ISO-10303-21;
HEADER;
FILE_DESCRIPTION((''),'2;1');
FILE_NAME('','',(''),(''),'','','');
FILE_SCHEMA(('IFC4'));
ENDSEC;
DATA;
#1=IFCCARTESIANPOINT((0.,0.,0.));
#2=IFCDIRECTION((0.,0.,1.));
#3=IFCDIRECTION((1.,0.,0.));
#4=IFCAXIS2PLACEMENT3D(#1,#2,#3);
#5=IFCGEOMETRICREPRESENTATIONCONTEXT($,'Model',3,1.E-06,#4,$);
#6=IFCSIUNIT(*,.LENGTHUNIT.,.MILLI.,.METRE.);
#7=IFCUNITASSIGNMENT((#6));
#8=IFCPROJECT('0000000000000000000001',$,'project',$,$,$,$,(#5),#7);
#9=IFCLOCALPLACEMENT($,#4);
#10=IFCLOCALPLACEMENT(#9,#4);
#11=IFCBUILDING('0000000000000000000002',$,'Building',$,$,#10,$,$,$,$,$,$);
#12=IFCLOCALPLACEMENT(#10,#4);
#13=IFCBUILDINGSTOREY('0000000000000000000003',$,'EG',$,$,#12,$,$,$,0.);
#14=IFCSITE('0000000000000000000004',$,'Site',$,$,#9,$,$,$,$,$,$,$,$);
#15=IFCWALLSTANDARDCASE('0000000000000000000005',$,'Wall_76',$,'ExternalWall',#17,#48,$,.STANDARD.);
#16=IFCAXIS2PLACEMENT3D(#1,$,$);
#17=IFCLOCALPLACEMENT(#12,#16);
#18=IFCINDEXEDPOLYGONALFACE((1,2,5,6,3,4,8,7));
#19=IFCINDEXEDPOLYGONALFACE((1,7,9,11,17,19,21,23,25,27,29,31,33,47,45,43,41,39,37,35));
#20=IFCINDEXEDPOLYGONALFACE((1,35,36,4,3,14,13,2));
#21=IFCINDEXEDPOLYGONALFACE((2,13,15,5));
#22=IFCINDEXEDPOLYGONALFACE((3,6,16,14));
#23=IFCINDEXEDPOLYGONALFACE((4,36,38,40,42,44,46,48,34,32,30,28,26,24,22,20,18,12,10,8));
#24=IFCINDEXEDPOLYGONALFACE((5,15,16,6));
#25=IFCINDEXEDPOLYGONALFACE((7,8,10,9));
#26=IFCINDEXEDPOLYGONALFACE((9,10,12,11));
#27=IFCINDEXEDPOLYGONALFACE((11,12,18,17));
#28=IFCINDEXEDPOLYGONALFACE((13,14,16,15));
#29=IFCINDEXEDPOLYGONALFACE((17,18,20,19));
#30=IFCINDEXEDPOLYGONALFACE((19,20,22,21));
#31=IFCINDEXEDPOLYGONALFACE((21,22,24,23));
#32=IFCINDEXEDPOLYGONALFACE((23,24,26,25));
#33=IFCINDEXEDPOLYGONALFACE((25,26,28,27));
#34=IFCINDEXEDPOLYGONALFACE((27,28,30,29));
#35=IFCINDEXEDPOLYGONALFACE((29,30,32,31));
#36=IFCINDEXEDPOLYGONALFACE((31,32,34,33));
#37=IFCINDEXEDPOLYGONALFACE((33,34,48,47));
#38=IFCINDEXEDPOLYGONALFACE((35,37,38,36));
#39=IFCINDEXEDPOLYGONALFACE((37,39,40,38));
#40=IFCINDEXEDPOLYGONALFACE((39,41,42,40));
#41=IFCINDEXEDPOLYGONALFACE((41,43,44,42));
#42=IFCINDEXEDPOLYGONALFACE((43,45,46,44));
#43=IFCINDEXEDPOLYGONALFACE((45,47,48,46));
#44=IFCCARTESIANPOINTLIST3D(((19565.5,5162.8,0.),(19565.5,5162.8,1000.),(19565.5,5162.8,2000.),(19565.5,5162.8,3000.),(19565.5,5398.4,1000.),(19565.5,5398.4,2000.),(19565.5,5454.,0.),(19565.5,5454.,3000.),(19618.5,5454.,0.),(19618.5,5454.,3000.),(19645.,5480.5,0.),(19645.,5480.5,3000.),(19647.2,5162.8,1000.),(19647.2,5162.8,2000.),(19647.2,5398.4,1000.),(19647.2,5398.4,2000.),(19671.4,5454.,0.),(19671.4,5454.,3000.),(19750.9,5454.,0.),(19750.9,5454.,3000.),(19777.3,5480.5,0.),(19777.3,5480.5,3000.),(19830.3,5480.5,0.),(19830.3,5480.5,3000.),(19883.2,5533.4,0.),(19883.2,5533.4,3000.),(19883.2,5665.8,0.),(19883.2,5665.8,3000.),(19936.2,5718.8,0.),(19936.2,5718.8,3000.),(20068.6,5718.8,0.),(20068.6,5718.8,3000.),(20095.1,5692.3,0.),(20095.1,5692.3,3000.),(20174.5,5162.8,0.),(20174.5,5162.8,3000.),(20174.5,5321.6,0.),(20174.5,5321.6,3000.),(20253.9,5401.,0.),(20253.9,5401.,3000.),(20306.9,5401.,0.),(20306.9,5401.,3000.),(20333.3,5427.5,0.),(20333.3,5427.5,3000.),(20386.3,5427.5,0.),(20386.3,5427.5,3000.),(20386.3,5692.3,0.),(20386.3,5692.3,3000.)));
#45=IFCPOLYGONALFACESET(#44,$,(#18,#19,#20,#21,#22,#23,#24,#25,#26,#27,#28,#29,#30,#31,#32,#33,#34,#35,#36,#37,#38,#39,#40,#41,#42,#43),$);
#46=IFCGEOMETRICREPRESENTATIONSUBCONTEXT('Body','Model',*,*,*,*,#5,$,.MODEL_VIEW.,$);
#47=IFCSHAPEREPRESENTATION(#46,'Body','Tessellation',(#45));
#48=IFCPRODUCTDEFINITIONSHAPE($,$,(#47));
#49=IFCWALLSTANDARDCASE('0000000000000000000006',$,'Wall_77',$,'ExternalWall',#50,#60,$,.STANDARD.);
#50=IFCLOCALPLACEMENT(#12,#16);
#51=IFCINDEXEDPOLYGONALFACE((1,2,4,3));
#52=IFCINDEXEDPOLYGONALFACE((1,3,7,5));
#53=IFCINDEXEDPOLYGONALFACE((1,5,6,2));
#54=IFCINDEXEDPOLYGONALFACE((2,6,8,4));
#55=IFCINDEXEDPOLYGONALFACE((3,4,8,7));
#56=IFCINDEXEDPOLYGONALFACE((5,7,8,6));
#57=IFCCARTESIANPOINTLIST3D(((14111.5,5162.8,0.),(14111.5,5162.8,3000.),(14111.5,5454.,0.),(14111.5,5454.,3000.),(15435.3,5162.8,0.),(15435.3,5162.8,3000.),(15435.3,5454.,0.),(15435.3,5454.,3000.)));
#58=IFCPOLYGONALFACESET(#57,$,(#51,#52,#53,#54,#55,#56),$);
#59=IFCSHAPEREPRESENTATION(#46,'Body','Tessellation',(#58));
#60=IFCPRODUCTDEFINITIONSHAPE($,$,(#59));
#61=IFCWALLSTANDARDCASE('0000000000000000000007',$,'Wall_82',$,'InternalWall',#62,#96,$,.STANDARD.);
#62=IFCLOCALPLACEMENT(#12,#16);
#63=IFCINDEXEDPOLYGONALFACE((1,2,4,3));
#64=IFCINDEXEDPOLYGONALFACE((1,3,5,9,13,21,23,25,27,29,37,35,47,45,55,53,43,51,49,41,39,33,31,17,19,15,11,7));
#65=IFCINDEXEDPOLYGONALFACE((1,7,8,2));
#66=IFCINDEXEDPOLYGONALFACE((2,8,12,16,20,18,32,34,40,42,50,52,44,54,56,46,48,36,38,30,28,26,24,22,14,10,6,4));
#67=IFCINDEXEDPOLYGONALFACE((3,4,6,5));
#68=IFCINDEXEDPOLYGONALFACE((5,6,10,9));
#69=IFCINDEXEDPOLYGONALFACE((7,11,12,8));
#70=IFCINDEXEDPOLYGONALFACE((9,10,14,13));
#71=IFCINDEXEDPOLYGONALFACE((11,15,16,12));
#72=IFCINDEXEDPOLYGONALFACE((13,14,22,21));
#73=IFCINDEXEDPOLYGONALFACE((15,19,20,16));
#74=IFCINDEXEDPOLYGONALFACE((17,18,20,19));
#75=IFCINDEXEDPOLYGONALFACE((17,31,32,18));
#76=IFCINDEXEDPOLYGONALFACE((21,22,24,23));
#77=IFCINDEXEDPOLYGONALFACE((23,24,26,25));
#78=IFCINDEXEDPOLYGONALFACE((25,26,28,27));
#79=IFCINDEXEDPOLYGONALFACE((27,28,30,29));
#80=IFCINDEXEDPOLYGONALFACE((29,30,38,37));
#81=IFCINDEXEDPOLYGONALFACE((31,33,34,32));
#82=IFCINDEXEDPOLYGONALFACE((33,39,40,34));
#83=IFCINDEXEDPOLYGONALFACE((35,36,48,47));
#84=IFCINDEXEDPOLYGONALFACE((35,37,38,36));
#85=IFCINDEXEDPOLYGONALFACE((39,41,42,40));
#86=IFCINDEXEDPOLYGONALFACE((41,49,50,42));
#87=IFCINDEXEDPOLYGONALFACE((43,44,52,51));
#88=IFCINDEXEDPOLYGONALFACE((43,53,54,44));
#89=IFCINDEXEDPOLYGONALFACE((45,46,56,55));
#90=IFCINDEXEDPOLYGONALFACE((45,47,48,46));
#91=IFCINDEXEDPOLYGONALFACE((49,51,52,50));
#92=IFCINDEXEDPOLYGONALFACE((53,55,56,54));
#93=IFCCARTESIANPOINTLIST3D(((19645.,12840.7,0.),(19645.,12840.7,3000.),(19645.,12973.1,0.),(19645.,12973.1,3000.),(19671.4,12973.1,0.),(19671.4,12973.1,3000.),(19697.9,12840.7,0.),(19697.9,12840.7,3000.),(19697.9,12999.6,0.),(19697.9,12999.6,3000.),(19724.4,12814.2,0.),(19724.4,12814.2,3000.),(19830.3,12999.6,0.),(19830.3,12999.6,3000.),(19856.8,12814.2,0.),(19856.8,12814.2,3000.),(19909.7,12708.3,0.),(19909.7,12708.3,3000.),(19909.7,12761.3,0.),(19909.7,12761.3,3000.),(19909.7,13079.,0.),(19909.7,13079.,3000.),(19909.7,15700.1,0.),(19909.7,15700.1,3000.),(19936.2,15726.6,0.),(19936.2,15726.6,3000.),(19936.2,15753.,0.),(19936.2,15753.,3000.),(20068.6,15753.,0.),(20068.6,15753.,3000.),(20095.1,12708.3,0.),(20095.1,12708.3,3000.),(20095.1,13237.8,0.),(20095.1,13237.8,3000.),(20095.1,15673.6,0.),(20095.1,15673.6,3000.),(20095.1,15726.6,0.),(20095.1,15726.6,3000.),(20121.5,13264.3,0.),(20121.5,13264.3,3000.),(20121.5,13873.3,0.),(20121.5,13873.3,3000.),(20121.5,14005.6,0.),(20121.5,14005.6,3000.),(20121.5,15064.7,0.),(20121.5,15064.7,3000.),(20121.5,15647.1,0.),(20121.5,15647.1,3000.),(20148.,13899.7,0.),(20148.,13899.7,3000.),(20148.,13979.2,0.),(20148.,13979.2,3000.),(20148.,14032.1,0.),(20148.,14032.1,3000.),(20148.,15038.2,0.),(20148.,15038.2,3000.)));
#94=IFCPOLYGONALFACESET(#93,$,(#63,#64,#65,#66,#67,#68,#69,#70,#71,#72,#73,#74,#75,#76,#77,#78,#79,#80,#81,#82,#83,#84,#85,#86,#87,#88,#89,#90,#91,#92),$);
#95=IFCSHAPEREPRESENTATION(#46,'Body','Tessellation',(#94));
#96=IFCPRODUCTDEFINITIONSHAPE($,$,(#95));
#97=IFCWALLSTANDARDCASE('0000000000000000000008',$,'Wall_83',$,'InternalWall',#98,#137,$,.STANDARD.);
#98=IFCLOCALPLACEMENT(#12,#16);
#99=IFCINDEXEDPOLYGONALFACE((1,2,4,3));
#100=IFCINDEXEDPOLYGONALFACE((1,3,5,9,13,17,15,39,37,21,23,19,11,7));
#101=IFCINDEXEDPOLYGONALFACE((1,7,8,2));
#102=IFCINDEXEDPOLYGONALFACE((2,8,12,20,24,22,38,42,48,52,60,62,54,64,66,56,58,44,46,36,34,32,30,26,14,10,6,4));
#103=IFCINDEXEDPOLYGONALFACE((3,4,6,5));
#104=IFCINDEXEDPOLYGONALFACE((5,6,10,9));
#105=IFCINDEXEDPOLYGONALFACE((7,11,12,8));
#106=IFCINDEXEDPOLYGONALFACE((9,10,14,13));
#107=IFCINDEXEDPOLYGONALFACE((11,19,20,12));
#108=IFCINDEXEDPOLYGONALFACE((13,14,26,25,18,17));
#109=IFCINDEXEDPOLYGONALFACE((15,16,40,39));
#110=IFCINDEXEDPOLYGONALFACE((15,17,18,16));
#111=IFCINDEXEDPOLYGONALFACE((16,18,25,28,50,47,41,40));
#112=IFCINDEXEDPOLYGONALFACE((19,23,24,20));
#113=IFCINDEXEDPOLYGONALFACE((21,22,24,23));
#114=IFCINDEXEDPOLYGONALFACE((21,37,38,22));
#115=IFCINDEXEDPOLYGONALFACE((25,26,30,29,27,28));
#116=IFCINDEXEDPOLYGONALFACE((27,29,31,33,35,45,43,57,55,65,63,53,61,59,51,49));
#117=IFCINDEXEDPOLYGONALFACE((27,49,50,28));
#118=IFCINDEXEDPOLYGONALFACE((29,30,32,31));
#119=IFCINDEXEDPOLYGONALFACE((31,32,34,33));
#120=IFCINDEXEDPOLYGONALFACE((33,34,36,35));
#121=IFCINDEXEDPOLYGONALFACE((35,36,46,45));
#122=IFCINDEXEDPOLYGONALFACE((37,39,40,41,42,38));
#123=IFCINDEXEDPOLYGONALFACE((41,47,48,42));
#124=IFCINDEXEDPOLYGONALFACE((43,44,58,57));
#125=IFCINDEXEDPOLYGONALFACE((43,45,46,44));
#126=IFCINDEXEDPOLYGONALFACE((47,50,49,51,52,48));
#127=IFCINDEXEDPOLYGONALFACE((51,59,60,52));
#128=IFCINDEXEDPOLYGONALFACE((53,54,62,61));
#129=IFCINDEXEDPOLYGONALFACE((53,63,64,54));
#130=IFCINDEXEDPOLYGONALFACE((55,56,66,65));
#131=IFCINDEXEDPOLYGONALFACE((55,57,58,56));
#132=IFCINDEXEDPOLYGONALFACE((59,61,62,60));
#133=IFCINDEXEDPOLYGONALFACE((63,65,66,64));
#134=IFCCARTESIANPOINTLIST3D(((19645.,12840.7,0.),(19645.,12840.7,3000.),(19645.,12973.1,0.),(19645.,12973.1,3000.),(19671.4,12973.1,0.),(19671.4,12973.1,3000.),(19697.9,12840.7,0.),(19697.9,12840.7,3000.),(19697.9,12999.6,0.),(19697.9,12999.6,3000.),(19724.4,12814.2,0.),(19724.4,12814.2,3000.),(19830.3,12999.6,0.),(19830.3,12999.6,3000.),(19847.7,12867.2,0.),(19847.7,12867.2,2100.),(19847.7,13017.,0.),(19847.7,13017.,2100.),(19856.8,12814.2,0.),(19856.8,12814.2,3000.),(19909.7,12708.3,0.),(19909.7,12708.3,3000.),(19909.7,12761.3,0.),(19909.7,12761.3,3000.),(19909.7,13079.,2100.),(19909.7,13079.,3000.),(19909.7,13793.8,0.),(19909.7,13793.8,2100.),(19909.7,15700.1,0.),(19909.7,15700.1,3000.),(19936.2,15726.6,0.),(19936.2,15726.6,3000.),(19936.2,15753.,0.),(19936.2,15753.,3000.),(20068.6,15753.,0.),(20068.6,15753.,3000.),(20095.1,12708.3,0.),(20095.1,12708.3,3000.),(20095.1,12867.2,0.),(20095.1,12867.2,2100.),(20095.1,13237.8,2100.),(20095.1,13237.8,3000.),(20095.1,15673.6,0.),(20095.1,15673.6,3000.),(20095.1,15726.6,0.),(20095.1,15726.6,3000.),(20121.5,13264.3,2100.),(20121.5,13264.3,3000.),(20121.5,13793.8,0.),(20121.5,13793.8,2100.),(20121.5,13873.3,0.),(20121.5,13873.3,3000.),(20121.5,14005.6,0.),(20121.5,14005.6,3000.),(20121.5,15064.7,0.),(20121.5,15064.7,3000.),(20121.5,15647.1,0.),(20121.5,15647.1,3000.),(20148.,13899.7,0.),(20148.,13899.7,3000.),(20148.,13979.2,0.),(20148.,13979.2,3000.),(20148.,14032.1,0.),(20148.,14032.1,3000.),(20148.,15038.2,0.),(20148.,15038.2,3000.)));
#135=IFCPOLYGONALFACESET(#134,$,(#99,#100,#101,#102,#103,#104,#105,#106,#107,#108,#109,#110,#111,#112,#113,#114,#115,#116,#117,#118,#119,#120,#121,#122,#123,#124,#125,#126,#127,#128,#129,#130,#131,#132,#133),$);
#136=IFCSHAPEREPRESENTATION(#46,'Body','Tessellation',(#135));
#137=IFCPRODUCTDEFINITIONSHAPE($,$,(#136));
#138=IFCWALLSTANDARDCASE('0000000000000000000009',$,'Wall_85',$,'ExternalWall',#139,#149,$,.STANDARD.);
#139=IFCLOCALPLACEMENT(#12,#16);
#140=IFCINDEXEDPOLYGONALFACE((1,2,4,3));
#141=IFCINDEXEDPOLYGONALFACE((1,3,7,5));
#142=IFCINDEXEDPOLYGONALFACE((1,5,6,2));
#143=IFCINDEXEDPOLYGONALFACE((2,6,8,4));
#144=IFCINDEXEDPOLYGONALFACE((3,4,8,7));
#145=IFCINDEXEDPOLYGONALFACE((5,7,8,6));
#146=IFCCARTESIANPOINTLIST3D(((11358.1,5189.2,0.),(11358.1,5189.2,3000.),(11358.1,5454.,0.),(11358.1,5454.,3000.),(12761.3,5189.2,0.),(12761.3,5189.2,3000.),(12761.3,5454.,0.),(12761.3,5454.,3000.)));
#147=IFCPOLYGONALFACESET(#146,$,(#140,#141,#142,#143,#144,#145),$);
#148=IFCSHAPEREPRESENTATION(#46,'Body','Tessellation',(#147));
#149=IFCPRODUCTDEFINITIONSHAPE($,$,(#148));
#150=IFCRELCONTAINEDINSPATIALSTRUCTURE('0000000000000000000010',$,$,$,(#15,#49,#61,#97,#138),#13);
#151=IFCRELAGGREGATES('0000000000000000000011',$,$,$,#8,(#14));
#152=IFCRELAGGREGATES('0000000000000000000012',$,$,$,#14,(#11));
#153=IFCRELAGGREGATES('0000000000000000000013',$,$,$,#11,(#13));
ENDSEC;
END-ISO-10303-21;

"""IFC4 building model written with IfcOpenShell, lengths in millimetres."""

from ifc_helpers import new_model, si_unit, frame, origin_with_axes, place, context, subcontext, project, spatial, polyline, rectangle, outline, extrude, element, save


model = new_model("IFC4")

# Units and contexts
model_context = context("Model", 3, precision=1e-06, world=origin_with_axes())
body_context = subcontext(model_context, "Body", "Model", "MODEL_VIEW")
ifc_project = project(units=[si_unit("LENGTHUNIT", "METRE", prefix="MILLI")], contexts=[model_context])

# Site, building, storey
site_placement = place(None, origin_with_axes())
site = spatial("IfcSite", under=ifc_project, at=site_placement, Name="Site")
building_placement = place(site_placement, origin_with_axes())
building = spatial("IfcBuilding", under=site, at=building_placement, Name="Building")
storey_placement = place(building_placement, origin_with_axes())
storey = spatial("IfcBuildingStorey", under=building, at=storey_placement, Name="EG", Elevation=0.0)

# Wall, opening
wall_1_placement = place(storey_placement, origin_with_axes())
wall_1 = element("IfcWallStandardCase", 1, at=wall_1_placement, inside=storey, Name="Wall_76", ObjectType="ExternalWall", PredefinedType="STANDARD", context=body_context, shape_type="SweptSolid", body=[
    extrude(outline(polyline([(19565.5, 5162.8, 0.0), (19565.5, 5454.0, 0.0), (19618.5, 5454.0, 0.0), (19645.0, 5480.5, 0.0), (19671.4, 5454.0, 0.0), (19750.9, 5454.0, 0.0), (19777.3, 5480.5, 0.0), (19830.3, 5480.5, 0.0), (19883.2, 5533.4, 0.0), (19883.2, 5665.8, 0.0), (19936.2, 5718.8, 0.0), (20068.6, 5718.8, 0.0), (20095.1, 5692.3, 0.0), (20386.3, 5692.3, 0.0), (20386.3, 5427.5, 0.0), (20333.3, 5427.5, 0.0), (20306.9, 5401.0, 0.0), (20253.9, 5401.0, 0.0), (20174.5, 5321.6, 0.0), (20174.5, 5162.8, 0.0), (19565.5, 5162.8, 0.0)])), origin_with_axes(), (0.0, 0.0, 1.0), 3000.0),
])
opening_1_placement = place(wall_1_placement, origin_with_axes())
element("IfcOpeningElement", 2, at=opening_1_placement, inside=storey, cuts=wall_1, context=body_context, shape_type="SweptSolid", body=[
    extrude(rectangle(XDim=694.1, YDim=240.0), frame((19527.2, 5051.4, 1000.0), z_axis=(0.0, 0.0, 1.0), x_axis=(0.0, 1.0, 0.0)), (0.0, 0.0, 1.0), 1000.0),
])

# Walls
for number, where, z_axis, x_axis, name in (
    (3, (0.0, 0.0, 0.0), (0.0, 0.0, 1.0), (1.0, 0.0, 0.0), "Wall_77"),
):
    element("IfcWallStandardCase", number, at=place(storey_placement, frame(where, z_axis=z_axis, x_axis=x_axis)), inside=storey, Name=name, ObjectType="ExternalWall", PredefinedType="STANDARD", context=body_context, shape_type="SweptSolid", body=[
        extrude(outline(polyline([(14111.5, 5162.8, 0.0), (14111.5, 5454.0, 0.0), (15435.3, 5454.0, 0.0), (15435.3, 5162.8, 0.0), (14111.5, 5162.8, 0.0)])), origin_with_axes(), (0.0, 0.0, 1.0), 3000.0),
    ])
wall_2_placement = place(storey_placement, origin_with_axes())
element("IfcWallStandardCase", 4, at=wall_2_placement, inside=storey, Name="Wall_82", ObjectType="InternalWall", PredefinedType="STANDARD", context=body_context, shape_type="SweptSolid", body=[
    extrude(outline(polyline([(19909.7, 12708.3, 0.0), (19909.7, 12761.3, 0.0), (19856.8, 12814.2, 0.0), (19724.4, 12814.2, 0.0), (19697.9, 12840.7, 0.0), (19645.0, 12840.7, 0.0), (19645.0, 12973.1, 0.0), (19671.4, 12973.1, 0.0), (19697.9, 12999.6, 0.0), (19830.3, 12999.6, 0.0), (19909.7, 13079.0, 0.0), (19909.7, 15700.1, 0.0), (19936.2, 15726.6, 0.0), (19936.2, 15753.0, 0.0), (20068.6, 15753.0, 0.0), (20095.1, 15726.6, 0.0), (20095.1, 15673.6, 0.0), (20121.5, 15647.1, 0.0), (20121.5, 15064.7, 0.0), (20148.0, 15038.2, 0.0), (20148.0, 14032.1, 0.0), (20121.5, 14005.6, 0.0), (20148.0, 13979.2, 0.0), (20148.0, 13899.7, 0.0), (20121.5, 13873.3, 0.0), (20121.5, 13264.3, 0.0), (20095.1, 13237.8, 0.0), (20095.1, 12708.3, 0.0), (19909.7, 12708.3, 0.0)])), origin_with_axes(), (0.0, 0.0, 1.0), 3000.0),
])

# Wall, opening
wall_3_placement = place(storey_placement, origin_with_axes())
wall_3 = element("IfcWallStandardCase", 5, at=wall_3_placement, inside=storey, Name="Wall_83", ObjectType="InternalWall", PredefinedType="STANDARD", context=body_context, shape_type="SweptSolid", body=[
    extrude(outline(polyline([(19909.7, 12708.3, 0.0), (19909.7, 12761.3, 0.0), (19856.8, 12814.2, 0.0), (19724.4, 12814.2, 0.0), (19697.9, 12840.7, 0.0), (19645.0, 12840.7, 0.0), (19645.0, 12973.1, 0.0), (19671.4, 12973.1, 0.0), (19697.9, 12999.6, 0.0), (19830.3, 12999.6, 0.0), (19909.7, 13079.0, 0.0), (19909.7, 15700.1, 0.0), (19936.2, 15726.6, 0.0), (19936.2, 15753.0, 0.0), (20068.6, 15753.0, 0.0), (20095.1, 15726.6, 0.0), (20095.1, 15673.6, 0.0), (20121.5, 15647.1, 0.0), (20121.5, 15064.7, 0.0), (20148.0, 15038.2, 0.0), (20148.0, 14032.1, 0.0), (20121.5, 14005.6, 0.0), (20148.0, 13979.2, 0.0), (20148.0, 13899.7, 0.0), (20121.5, 13873.3, 0.0), (20121.5, 13264.3, 0.0), (20095.1, 13237.8, 0.0), (20095.1, 12708.3, 0.0), (19909.7, 12708.3, 0.0)])), origin_with_axes(), (0.0, 0.0, 1.0), 3000.0),
])
opening_2_placement = place(wall_3_placement, origin_with_axes())
element("IfcOpeningElement", 6, at=opening_2_placement, inside=storey, cuts=wall_3, context=body_context, shape_type="SweptSolid", body=[
    extrude(rectangle(XDim=926.6, YDim=300.0), frame((19997.7, 13330.5, 0.0), z_axis=(0.0, 0.0, 1.0), x_axis=(0.0, 1.0, 0.0)), (0.0, 0.0, 1.0), 2100.0),
])

# Wall
for number, where, z_axis, x_axis, name in (
    (7, (0.0, 0.0, 0.0), (0.0, 0.0, 1.0), (1.0, 0.0, 0.0), "Wall_85"),
):
    element("IfcWallStandardCase", number, at=place(storey_placement, frame(where, z_axis=z_axis, x_axis=x_axis)), inside=storey, Name=name, ObjectType="ExternalWall", PredefinedType="STANDARD", context=body_context, shape_type="SweptSolid", body=[
        extrude(outline(polyline([(11358.1, 5189.2, 0.0), (11358.1, 5454.0, 0.0), (12761.3, 5454.0, 0.0), (12761.3, 5189.2, 0.0), (11358.1, 5189.2, 0.0)])), origin_with_axes(), (0.0, 0.0, 1.0), 3000.0),
    ])

save(model, "model.ifc")
